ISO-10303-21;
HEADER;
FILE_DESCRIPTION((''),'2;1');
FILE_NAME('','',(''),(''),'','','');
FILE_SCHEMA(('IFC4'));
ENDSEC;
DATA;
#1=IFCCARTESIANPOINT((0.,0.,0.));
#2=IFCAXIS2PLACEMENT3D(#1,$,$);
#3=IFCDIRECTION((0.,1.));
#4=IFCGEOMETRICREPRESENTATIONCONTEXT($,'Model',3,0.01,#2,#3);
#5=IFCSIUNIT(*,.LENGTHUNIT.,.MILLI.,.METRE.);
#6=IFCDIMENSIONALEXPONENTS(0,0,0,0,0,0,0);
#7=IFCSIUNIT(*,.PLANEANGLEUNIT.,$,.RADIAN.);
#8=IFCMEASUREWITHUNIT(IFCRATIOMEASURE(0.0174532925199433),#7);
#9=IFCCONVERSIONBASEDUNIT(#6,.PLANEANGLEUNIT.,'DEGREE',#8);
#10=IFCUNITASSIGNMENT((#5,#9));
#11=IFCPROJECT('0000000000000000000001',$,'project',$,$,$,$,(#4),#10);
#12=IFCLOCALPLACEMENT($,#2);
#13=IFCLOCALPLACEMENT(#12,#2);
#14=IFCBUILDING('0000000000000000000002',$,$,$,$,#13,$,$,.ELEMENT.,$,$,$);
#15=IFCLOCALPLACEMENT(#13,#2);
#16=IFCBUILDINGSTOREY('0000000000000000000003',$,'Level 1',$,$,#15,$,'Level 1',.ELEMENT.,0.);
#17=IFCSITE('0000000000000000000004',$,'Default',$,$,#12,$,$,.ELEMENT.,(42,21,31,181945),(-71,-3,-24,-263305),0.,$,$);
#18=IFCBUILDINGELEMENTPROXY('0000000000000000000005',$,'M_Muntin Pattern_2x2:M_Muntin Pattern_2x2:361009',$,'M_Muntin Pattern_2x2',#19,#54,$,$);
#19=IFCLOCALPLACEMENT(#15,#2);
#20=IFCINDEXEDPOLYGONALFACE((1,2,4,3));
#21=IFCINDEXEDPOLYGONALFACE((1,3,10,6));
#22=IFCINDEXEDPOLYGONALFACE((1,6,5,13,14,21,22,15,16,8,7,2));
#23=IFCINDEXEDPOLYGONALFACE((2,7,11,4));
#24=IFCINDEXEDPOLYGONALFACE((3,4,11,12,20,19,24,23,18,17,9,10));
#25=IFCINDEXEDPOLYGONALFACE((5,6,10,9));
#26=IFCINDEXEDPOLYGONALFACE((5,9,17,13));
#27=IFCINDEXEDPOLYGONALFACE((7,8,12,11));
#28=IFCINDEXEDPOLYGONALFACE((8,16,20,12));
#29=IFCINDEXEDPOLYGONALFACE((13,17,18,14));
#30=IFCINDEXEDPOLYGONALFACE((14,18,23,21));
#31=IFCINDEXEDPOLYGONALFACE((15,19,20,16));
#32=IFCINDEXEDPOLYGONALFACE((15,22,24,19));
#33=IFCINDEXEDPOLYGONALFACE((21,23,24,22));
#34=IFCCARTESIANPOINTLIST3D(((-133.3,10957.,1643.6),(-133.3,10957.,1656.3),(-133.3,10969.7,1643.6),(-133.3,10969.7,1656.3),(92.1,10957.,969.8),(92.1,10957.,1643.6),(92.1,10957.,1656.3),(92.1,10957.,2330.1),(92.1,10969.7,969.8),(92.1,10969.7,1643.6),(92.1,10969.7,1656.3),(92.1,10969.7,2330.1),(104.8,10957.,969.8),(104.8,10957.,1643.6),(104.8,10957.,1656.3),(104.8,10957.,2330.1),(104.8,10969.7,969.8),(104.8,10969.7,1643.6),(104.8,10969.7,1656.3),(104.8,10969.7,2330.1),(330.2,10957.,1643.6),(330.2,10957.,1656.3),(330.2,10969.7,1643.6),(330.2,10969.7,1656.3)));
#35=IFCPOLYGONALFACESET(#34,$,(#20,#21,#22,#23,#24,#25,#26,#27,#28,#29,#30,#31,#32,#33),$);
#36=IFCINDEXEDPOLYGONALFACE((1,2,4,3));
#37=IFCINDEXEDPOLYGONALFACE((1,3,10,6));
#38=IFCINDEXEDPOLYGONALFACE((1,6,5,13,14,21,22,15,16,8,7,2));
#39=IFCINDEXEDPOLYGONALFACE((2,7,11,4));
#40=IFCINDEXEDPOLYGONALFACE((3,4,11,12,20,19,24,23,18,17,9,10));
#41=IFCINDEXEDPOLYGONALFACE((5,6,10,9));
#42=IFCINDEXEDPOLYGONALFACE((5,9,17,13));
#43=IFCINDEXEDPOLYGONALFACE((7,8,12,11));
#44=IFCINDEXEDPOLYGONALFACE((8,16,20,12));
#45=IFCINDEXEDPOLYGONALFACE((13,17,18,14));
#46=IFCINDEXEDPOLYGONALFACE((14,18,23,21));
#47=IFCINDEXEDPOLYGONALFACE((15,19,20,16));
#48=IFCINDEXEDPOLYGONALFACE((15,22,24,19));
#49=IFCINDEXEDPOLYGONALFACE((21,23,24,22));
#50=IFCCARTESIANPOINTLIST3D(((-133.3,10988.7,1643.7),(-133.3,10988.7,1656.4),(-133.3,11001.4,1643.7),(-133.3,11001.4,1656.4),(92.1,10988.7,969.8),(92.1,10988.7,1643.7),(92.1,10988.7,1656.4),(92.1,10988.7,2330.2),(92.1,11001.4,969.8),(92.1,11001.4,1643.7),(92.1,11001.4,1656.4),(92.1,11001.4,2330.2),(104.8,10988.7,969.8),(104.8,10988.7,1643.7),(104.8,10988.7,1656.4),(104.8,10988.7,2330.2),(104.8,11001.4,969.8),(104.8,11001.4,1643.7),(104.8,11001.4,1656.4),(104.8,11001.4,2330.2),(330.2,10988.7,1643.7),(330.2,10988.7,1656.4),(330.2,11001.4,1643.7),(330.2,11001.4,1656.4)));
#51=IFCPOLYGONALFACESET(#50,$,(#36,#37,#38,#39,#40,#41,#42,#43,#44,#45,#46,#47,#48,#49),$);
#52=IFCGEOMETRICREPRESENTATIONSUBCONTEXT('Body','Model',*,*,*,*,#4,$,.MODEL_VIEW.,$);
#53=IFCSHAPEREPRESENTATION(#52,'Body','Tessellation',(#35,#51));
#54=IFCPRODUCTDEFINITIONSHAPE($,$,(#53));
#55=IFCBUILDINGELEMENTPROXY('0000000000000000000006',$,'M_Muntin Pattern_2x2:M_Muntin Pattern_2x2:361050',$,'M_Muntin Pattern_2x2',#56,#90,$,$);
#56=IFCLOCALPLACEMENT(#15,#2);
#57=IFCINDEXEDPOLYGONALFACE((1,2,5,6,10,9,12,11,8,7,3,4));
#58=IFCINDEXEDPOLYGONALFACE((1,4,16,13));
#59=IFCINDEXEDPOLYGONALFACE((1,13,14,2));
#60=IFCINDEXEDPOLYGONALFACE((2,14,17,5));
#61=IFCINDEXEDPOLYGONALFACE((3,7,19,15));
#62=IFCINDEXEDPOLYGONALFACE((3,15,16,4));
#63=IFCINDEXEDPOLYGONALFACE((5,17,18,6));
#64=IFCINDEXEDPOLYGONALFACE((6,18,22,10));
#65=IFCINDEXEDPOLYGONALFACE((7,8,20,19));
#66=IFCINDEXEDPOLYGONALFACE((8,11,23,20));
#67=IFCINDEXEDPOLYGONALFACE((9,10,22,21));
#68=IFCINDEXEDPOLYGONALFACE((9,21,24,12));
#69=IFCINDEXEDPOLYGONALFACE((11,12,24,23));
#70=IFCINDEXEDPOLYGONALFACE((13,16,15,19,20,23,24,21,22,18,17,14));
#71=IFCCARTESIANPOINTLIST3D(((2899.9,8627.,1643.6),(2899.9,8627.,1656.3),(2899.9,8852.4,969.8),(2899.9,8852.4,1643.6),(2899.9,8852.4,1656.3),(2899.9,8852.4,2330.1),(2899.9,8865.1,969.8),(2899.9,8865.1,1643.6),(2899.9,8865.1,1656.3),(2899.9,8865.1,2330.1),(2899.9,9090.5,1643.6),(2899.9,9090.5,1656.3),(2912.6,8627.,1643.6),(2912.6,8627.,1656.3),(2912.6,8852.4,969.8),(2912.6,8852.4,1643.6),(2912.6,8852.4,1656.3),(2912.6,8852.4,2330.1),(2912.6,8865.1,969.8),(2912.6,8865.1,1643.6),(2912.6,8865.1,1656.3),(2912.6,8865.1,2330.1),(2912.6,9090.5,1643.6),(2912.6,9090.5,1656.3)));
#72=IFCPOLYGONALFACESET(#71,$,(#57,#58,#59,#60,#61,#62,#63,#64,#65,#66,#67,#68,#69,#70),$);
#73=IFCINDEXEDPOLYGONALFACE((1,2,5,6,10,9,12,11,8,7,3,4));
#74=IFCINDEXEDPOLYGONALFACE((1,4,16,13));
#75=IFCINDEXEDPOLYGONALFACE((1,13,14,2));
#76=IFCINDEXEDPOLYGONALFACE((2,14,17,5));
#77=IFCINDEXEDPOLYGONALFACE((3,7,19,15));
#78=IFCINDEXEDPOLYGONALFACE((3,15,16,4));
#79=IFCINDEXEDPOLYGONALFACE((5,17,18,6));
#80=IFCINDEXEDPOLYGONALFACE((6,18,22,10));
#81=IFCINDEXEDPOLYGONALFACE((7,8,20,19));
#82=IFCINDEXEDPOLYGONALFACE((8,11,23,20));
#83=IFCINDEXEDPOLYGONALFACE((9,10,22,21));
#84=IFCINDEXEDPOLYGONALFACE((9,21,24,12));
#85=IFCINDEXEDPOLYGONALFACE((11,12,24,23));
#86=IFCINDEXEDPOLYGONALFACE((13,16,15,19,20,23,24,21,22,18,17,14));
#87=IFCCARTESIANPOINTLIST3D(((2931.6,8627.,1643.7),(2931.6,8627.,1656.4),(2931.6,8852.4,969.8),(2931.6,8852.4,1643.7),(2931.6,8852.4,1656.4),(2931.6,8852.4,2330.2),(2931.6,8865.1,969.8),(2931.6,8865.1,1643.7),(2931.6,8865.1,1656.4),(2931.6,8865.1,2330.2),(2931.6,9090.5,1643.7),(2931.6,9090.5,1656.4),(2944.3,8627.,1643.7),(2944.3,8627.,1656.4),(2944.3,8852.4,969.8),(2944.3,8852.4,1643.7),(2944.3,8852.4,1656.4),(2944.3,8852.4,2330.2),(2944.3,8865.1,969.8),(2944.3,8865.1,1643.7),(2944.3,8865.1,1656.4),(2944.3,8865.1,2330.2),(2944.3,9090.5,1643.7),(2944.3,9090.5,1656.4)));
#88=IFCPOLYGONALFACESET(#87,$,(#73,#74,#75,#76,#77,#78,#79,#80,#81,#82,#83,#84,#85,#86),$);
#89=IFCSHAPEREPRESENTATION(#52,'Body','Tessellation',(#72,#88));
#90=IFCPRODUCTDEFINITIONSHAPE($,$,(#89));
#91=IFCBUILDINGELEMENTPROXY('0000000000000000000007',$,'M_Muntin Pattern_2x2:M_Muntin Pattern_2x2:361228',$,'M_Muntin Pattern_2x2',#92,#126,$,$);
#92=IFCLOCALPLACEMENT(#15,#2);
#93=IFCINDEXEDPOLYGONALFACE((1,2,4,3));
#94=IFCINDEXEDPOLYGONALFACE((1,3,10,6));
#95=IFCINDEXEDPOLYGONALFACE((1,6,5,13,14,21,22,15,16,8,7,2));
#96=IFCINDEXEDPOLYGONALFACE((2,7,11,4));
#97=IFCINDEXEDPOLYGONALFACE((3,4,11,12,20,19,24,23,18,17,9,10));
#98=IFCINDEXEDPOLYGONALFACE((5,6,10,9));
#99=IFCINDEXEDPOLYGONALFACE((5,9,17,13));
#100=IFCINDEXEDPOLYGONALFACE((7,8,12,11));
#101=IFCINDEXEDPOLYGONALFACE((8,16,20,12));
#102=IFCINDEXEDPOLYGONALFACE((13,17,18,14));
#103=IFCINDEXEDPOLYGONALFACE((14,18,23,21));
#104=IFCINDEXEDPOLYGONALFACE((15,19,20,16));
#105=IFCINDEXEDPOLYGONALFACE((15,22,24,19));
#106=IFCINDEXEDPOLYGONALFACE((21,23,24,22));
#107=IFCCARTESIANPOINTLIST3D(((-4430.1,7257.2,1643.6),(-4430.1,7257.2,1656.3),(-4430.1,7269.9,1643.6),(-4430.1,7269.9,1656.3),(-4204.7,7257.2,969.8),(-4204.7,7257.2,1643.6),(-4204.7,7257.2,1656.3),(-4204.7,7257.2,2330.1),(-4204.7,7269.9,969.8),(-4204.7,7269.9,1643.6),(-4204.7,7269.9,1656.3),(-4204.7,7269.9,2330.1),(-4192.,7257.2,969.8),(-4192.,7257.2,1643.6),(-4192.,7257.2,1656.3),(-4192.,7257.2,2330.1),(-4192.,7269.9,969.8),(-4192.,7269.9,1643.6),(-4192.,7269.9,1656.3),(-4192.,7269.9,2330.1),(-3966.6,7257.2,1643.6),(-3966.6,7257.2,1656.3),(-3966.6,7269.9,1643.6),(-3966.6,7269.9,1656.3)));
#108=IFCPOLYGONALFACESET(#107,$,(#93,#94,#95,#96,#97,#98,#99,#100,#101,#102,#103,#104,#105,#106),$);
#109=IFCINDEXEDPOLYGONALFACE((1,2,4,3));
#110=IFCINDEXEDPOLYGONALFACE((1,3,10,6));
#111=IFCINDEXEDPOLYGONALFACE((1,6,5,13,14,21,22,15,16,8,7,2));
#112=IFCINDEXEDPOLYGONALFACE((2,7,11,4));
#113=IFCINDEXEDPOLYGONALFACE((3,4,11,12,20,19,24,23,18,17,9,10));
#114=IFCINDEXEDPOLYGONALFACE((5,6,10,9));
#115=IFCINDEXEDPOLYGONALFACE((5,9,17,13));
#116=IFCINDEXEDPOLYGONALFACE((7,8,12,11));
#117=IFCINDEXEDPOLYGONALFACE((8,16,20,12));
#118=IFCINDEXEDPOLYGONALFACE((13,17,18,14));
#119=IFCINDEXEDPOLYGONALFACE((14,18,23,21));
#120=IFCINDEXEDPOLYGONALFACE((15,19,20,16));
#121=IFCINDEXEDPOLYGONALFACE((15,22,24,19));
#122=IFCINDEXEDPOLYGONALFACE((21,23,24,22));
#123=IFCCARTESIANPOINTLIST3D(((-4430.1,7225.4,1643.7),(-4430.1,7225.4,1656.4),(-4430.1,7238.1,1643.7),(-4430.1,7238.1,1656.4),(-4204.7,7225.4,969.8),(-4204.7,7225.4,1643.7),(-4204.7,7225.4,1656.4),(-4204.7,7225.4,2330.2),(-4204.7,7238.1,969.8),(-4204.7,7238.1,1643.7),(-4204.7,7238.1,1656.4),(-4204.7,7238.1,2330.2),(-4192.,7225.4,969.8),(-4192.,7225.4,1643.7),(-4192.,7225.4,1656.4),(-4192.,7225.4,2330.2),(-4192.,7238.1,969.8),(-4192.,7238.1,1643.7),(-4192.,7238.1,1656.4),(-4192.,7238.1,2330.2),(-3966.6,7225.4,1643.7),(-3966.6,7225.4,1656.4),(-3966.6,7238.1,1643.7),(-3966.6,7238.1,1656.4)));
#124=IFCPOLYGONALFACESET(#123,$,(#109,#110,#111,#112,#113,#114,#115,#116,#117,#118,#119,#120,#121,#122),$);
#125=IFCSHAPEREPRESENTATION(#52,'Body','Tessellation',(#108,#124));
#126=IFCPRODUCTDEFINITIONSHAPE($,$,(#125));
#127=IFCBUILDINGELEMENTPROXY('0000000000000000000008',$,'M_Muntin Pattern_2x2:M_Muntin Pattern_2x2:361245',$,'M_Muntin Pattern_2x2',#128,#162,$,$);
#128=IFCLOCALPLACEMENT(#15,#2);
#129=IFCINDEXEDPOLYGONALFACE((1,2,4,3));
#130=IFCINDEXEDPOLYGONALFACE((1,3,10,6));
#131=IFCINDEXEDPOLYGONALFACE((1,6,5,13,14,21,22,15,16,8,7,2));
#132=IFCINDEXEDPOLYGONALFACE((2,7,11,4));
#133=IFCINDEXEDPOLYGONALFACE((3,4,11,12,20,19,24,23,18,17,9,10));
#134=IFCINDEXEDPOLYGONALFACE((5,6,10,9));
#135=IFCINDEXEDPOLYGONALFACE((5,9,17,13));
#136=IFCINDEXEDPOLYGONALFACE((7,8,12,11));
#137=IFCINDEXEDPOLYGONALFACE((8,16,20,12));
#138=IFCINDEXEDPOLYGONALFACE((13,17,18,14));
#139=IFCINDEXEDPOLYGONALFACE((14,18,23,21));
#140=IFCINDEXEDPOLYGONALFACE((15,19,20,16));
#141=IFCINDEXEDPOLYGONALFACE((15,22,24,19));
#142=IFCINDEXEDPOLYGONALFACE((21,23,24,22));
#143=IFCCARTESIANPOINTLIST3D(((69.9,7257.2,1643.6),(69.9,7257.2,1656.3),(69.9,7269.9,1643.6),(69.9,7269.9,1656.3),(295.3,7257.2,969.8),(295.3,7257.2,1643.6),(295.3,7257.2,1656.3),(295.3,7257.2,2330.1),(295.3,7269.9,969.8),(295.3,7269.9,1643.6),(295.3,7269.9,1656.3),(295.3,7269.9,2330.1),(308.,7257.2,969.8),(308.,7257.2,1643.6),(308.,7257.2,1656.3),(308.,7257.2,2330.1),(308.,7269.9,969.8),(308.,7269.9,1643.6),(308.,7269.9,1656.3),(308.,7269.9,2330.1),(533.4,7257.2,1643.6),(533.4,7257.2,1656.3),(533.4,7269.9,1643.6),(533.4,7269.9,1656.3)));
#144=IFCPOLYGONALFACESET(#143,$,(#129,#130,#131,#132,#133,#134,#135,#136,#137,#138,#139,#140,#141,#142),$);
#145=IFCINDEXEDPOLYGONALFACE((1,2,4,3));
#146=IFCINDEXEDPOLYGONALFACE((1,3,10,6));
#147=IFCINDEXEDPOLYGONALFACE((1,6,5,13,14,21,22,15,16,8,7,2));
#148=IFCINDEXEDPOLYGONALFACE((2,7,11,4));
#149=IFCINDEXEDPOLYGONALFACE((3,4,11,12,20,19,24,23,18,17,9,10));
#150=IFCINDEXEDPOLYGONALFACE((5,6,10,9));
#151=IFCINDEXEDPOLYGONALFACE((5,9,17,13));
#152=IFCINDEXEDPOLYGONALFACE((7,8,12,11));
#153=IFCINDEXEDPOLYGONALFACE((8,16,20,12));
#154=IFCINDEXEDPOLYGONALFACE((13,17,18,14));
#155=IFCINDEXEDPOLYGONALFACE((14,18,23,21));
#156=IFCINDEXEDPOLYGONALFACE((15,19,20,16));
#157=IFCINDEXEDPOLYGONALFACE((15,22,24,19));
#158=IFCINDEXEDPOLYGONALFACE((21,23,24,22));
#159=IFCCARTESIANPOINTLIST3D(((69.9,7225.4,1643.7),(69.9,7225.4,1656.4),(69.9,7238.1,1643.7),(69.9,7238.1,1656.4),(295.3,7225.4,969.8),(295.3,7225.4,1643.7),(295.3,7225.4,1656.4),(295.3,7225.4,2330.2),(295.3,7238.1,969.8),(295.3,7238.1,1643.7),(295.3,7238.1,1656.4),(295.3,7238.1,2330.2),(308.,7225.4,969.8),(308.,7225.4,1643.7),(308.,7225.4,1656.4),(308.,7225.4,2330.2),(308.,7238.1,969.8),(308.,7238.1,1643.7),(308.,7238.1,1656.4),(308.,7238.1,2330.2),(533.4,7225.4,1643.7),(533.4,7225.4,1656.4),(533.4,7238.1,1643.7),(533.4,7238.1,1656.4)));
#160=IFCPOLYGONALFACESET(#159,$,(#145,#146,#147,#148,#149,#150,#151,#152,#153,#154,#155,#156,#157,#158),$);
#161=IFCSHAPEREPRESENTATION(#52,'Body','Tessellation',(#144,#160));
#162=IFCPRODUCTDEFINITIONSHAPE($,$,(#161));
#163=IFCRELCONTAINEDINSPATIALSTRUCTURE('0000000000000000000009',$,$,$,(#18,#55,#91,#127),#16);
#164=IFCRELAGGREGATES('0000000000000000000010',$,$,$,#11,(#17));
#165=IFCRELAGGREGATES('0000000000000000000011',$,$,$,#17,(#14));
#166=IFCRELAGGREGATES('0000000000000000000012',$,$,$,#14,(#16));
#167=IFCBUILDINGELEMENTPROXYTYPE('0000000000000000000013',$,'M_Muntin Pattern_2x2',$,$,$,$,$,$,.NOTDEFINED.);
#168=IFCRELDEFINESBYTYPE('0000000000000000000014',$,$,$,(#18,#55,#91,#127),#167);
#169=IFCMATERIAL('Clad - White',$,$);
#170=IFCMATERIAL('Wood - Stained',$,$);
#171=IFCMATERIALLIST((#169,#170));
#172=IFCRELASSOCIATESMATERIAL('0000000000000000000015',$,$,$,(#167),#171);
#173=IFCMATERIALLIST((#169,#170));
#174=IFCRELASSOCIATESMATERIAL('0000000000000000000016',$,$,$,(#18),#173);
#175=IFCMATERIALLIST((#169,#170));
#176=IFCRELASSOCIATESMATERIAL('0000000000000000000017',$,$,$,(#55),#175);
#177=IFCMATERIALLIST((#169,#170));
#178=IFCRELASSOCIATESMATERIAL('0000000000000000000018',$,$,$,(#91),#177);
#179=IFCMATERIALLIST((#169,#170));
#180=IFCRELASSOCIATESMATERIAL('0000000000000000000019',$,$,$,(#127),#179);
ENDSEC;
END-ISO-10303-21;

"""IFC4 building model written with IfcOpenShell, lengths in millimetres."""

from ifc_helpers import new_model, entity, si_unit, converted_unit, direction, frame, origin, place, context, subcontext, project, spatial, polyline, outline, extrude, source, transform, mapped, material, material_list, type_object, type_shapes, element, save


model = new_model("IFC4")

# Units and contexts
model_context = context("Model", 3, precision=0.01, world=origin(), true_north=direction((0.0, 1.0)))
body_context = subcontext(model_context, "Body", "Model", "MODEL_VIEW")
ifc_project = project(units=[si_unit("LENGTHUNIT", "METRE", prefix="MILLI"), converted_unit("PLANEANGLEUNIT", "DEGREE", entity("IfcRatioMeasure", 0.0174532925199433), si_unit("PLANEANGLEUNIT", "RADIAN"), dimensions=[0, 0, 0, 0, 0, 0, 0])], contexts=[model_context])

# Site, building, storey
site_placement = place(None, origin())
site = spatial("IfcSite", under=ifc_project, at=site_placement, Name="Default", CompositionType="ELEMENT", RefLatitude=(42, 21, 31, 181945), RefLongitude=(-71, -3, -24, -263305), RefElevation=0.0)
building_placement = place(site_placement, origin())
building = spatial("IfcBuilding", under=site, at=building_placement, CompositionType="ELEMENT")
storey_placement = place(building_placement, origin())
storey = spatial("IfcBuildingStorey", under=building, at=storey_placement, Name="Level 1", LongName="Level 1", CompositionType="ELEMENT", Elevation=0.0)

# Building element proxies
ifc_material_1 = material(Name="Clad - White")
ifc_material_2 = material(Name="Wood - Stained")
ifc_material_list_1 = material_list([ifc_material_1, ifc_material_2])
building_element_proxy_type_1 = type_object("IfcBuildingElementProxyType", Name="M_Muntin Pattern_2x2", PredefinedType="NOTDEFINED", material=ifc_material_list_1)
shared_shape_1 = source(origin(), body_context, "Body", "SweptSolid", [
    extrude(outline(polyline([(6.4, -6.4), (680.1, -6.4), (680.1, 6.3), (6.4, 6.3), (6.4, 231.7), (-6.3, 231.7), (-6.3, 6.3), (-680.2, 6.3), (-680.2, -6.4), (-6.3, -6.4), (-6.3, -231.7), (6.4, -231.7), (6.4, -6.4)])), frame((0.0, 9.5, 680.1), z_axis=(0.0, 1.0, 0.0), x_axis=(0.0, 0.0, 1.0)), (0.0, 0.0, 1.0), 12.7),
    extrude(outline(polyline([(6.4, -6.4), (680.2, -6.4), (680.2, 6.3), (6.4, 6.3), (6.4, 231.7), (-6.3, 231.7), (-6.3, 6.3), (-680.2, 6.3), (-680.2, -6.4), (-6.3, -6.4), (-6.3, -231.7), (6.4, -231.7), (6.4, -6.4)])), frame((0.0, -22.2, 680.2), z_axis=(0.0, 1.0, 0.0), x_axis=(0.0, 0.0, 1.0)), (0.0, 0.0, 1.0), 12.7),
])
type_shapes(building_element_proxy_type_1, [shared_shape_1])
ifc_material_list_2 = material_list([ifc_material_1, ifc_material_2])
proxy_1_placement = place(storey_placement, frame((98.5, 10979.2, 969.8), z_axis=(0.0, 0.0, 1.0), x_axis=(-1.0, 0.0, 0.0)))
element("IfcBuildingElementProxy", 1, at=proxy_1_placement, inside=storey, type_object=building_element_proxy_type_1, material=ifc_material_list_2, Name="M_Muntin Pattern_2x2:M_Muntin Pattern_2x2:361009", ObjectType="M_Muntin Pattern_2x2", context=body_context, shape_type="MappedRepresentation", body=[
    mapped(shared_shape_1, transform((0.0, 0.0, 0.0), scale=1.0)),
])
ifc_material_list_3 = material_list([ifc_material_1, ifc_material_2])
proxy_2_placement = place(storey_placement, frame((2922.1, 8858.7, 969.8), z_axis=(0.0, 0.0, 1.0), x_axis=(0.0, 1.0, 0.0)))
element("IfcBuildingElementProxy", 2, at=proxy_2_placement, inside=storey, type_object=building_element_proxy_type_1, material=ifc_material_list_3, Name="M_Muntin Pattern_2x2:M_Muntin Pattern_2x2:361050", ObjectType="M_Muntin Pattern_2x2", context=body_context, shape_type="MappedRepresentation", body=[
    mapped(shared_shape_1, transform((0.0, 0.0, 0.0), scale=1.0)),
])
ifc_material_list_4 = material_list([ifc_material_1, ifc_material_2])
proxy_3_placement = place(storey_placement, frame((-4198.4, 7247.6, 969.8)))
element("IfcBuildingElementProxy", 3, at=proxy_3_placement, inside=storey, type_object=building_element_proxy_type_1, material=ifc_material_list_4, Name="M_Muntin Pattern_2x2:M_Muntin Pattern_2x2:361228", ObjectType="M_Muntin Pattern_2x2", context=body_context, shape_type="MappedRepresentation", body=[
    mapped(shared_shape_1, transform((0.0, 0.0, 0.0), scale=1.0)),
])
ifc_material_list_5 = material_list([ifc_material_1, ifc_material_2])
proxy_4_placement = place(storey_placement, frame((301.6, 7247.6, 969.8)))
element("IfcBuildingElementProxy", 4, at=proxy_4_placement, inside=storey, type_object=building_element_proxy_type_1, material=ifc_material_list_5, Name="M_Muntin Pattern_2x2:M_Muntin Pattern_2x2:361245", ObjectType="M_Muntin Pattern_2x2", context=body_context, shape_type="MappedRepresentation", body=[
    mapped(shared_shape_1, transform((0.0, 0.0, 0.0), scale=1.0)),
])

save(model, "model.ifc")
